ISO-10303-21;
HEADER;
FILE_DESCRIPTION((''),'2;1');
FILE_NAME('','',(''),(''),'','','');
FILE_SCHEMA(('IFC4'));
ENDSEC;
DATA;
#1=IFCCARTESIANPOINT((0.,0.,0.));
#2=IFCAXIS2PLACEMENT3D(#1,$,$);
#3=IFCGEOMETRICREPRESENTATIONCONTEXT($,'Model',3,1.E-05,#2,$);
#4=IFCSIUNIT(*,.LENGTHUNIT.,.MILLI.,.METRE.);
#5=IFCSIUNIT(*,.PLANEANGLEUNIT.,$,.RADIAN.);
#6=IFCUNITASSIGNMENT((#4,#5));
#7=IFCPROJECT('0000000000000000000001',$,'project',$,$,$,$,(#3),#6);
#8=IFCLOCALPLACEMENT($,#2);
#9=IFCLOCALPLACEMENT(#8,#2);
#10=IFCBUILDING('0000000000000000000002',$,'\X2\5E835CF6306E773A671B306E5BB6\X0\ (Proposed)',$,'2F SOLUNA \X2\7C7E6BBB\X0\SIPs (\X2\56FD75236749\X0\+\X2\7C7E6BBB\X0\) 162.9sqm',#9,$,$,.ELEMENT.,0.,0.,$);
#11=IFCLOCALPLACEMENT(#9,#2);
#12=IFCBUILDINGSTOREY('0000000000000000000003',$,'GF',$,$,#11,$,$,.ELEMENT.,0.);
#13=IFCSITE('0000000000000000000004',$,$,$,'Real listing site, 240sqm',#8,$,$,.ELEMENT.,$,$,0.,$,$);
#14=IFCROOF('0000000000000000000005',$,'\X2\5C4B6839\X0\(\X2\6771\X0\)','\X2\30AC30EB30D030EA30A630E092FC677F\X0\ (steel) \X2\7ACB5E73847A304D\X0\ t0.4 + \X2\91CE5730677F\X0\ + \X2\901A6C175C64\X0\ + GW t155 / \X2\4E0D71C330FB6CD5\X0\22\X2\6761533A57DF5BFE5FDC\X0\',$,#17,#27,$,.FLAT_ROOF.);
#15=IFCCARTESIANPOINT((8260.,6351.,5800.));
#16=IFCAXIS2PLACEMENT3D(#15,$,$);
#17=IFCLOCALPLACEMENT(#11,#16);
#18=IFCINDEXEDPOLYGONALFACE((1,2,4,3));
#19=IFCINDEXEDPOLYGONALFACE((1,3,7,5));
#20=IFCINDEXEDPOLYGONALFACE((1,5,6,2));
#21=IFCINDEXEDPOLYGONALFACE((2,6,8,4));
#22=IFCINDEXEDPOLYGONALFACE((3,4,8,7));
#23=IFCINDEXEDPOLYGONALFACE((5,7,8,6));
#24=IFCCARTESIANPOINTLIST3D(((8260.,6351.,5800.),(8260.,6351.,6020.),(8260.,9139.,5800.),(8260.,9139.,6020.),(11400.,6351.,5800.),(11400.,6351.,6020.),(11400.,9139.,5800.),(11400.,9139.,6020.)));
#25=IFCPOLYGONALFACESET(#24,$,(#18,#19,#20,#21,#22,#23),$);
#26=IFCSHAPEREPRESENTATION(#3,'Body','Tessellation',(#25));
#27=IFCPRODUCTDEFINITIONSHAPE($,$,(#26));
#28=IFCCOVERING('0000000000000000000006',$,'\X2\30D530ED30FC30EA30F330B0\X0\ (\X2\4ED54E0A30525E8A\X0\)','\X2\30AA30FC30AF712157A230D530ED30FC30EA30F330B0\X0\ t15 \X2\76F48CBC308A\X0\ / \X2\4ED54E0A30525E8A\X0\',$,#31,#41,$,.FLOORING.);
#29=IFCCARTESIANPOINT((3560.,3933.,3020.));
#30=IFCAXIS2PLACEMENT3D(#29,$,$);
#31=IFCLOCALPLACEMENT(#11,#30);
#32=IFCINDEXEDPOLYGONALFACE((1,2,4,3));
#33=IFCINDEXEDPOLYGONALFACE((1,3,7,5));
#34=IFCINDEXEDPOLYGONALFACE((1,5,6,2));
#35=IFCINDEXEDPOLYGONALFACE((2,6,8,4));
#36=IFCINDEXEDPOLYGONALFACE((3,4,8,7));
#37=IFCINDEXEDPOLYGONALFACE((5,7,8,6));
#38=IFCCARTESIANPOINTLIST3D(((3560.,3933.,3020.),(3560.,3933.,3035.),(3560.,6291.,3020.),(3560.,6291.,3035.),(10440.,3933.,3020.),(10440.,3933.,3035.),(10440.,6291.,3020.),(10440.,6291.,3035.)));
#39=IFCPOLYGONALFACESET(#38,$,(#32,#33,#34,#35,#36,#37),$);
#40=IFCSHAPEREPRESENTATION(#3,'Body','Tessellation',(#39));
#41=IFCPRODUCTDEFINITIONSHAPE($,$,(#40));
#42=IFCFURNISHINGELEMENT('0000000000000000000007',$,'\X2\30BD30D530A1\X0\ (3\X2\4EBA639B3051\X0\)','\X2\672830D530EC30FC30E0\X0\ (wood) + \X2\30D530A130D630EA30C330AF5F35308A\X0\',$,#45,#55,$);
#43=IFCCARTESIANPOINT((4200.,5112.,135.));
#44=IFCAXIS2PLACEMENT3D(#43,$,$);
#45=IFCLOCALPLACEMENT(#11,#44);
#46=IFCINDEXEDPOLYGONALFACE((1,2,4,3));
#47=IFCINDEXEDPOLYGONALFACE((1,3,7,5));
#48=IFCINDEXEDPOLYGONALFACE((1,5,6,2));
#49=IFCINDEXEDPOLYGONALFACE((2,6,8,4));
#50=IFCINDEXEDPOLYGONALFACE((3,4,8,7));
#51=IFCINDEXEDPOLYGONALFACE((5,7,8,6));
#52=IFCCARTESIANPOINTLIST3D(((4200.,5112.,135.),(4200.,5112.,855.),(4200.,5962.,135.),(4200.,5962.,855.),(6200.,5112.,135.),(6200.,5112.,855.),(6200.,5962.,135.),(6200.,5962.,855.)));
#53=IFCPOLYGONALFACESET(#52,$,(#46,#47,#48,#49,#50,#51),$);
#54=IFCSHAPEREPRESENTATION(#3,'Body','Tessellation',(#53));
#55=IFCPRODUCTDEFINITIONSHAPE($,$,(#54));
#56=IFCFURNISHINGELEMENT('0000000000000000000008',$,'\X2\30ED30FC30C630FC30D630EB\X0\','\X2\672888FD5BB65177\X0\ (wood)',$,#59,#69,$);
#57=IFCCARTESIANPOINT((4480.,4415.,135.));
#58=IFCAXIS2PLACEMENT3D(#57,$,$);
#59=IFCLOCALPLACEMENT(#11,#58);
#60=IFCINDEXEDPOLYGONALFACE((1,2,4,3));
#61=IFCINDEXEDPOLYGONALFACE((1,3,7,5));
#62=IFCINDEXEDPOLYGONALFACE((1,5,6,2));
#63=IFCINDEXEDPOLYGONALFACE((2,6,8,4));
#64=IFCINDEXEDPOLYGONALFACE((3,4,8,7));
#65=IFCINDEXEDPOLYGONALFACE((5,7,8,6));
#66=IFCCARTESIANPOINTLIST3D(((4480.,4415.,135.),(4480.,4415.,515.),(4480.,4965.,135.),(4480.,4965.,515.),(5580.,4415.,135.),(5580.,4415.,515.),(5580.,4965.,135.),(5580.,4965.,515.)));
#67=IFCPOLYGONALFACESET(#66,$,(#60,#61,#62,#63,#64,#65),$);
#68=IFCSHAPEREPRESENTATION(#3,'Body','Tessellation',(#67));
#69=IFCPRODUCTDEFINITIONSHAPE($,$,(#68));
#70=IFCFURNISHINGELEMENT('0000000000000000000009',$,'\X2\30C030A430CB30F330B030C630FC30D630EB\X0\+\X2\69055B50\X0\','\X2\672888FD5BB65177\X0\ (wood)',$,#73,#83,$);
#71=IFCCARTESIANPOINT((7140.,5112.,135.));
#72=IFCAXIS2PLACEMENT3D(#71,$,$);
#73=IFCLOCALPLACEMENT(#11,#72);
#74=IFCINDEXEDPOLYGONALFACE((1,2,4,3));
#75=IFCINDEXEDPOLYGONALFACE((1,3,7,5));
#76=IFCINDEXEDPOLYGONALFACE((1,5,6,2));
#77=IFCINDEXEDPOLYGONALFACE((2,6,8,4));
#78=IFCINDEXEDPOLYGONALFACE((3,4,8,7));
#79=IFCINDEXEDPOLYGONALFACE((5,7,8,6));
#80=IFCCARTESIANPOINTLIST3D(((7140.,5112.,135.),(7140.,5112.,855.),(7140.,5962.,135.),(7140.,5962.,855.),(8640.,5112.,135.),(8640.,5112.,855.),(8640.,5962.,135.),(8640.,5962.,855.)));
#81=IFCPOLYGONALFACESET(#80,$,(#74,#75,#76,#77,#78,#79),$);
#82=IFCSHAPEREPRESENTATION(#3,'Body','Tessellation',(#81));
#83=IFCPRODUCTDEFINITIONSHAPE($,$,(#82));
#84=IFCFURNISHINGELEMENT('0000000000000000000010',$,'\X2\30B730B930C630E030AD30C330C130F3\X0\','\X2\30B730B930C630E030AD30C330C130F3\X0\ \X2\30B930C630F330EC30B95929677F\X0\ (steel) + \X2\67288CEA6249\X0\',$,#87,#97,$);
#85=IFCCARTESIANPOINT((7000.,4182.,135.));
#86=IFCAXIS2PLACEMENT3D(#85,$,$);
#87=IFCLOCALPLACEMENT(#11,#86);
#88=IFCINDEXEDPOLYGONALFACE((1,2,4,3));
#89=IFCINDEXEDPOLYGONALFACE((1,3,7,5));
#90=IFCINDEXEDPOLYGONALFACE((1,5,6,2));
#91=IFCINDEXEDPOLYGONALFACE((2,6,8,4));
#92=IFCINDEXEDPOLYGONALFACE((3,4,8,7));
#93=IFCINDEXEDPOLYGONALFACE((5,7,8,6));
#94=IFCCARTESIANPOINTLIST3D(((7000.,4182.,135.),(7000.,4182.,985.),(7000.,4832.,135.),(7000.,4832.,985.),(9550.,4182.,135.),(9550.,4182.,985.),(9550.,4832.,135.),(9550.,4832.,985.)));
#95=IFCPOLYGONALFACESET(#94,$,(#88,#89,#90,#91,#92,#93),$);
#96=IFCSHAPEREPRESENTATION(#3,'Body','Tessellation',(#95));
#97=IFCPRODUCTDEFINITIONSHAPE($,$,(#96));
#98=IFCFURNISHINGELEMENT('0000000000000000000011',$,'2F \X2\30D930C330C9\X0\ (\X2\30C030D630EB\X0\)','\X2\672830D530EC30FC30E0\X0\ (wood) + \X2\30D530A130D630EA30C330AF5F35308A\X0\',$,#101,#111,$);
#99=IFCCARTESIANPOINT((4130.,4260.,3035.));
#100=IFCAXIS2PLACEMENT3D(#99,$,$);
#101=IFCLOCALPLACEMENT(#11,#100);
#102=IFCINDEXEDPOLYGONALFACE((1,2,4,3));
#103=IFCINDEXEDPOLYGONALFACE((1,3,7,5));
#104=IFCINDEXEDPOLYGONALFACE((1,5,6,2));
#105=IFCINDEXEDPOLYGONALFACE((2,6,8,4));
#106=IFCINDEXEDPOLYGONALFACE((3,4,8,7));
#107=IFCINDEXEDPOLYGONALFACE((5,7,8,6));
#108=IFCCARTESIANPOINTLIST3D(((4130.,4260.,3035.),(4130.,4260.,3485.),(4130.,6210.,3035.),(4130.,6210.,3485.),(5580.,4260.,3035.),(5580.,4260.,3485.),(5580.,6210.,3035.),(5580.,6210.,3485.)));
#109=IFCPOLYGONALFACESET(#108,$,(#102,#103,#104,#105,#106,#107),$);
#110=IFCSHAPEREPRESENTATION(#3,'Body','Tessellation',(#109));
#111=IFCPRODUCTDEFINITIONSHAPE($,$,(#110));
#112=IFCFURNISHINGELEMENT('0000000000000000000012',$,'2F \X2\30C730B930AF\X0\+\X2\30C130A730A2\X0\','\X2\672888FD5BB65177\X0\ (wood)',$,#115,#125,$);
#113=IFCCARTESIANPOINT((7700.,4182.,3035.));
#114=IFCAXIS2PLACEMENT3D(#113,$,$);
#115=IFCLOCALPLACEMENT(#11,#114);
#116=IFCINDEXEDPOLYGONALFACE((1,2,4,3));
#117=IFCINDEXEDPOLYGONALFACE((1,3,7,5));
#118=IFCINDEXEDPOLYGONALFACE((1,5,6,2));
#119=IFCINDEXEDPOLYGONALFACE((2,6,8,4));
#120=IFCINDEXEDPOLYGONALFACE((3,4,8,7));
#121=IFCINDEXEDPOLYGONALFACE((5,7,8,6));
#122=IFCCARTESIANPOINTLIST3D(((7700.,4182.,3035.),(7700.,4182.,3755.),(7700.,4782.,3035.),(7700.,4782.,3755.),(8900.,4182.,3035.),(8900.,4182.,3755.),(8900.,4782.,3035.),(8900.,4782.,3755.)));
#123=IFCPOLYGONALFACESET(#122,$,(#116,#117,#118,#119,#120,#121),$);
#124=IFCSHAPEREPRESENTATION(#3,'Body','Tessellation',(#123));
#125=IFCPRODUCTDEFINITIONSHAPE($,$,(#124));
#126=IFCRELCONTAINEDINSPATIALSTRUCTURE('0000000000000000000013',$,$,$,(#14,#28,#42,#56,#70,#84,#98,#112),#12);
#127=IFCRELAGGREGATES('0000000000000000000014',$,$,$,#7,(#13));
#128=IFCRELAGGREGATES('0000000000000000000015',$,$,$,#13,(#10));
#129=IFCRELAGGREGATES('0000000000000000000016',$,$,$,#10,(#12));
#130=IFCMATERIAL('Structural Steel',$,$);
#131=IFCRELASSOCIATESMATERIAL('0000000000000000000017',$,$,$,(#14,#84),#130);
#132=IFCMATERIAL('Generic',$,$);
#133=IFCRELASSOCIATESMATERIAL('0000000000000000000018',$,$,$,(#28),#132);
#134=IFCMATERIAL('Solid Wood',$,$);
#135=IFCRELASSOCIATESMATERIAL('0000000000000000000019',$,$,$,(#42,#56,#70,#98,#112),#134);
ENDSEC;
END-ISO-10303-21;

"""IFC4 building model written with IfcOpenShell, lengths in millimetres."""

from ifc_helpers import new_model, si_unit, frame, frame_2d, origin, place, context, project, spatial, rectangle, extrude, material, element, save


model = new_model("IFC4")

# Units and contexts
model_context = context("Model", 3, precision=1e-05, world=origin())
ifc_project = project(units=[si_unit("LENGTHUNIT", "METRE", prefix="MILLI"), si_unit("PLANEANGLEUNIT", "RADIAN")], contexts=[model_context])

# Site, building, storey
site_placement = place(None, origin())
site = spatial("IfcSite", under=ifc_project, at=site_placement, ObjectType="Real listing site, 240sqm", CompositionType="ELEMENT", RefElevation=0.0)
building_placement = place(site_placement, origin())
building = spatial("IfcBuilding", under=site, at=building_placement, Name="広島の眺望の家 (Proposed)", ObjectType="2F SOLUNA 籾殻SIPs (国産杉+籾殻) 162.9sqm", CompositionType="ELEMENT", ElevationOfRefHeight=0.0, ElevationOfTerrain=0.0)
storey_placement = place(building_placement, origin())
storey = spatial("IfcBuildingStorey", under=building, at=storey_placement, Name="GF", CompositionType="ELEMENT", Elevation=0.0)

# Shared definitions
ifc_material_1 = material(Name="Solid Wood")

# Shared definitions
ifc_material_2 = material(Name="Generic")

# Roof
ifc_material_3 = material(Name="Structural Steel")
roof_placement = place(storey_placement, frame((8260.0, 6351.0, 5800.0)))
element("IfcRoof", 1, at=roof_placement, inside=storey, material=ifc_material_3, Name="屋根(東)", Description="ガルバリウム鋼板 (steel) 立平葺き t0.4 + 野地板 + 通気層 + GW t155 / 不燃・法22条区域対応", PredefinedType="FLAT_ROOF", context=model_context, shape_type="SweptSolid", body=[
    extrude(rectangle(XDim=3140.0, YDim=2788.0, at=frame_2d((1570.0, 1394.0))), frame((8260.0, 6351.0, 5800.0)), (0.0, 0.0, 1.0), 220.0),
])

# Covering
covering_placement = place(storey_placement, frame((3560.0, 3933.0, 3020.0)))
element("IfcCovering", 2, at=covering_placement, inside=storey, material=ifc_material_2, Name="フローリング (仕上げ床)", Description="オーク無垢フローリング t15 直貼り / 仕上げ床", PredefinedType="FLOORING", context=model_context, shape_type="SweptSolid", body=[
    extrude(rectangle(XDim=6880.0, YDim=2358.0, at=frame_2d((3440.0, 1179.0))), frame((3560.0, 3933.0, 3020.0)), (0.0, 0.0, 1.0), 15.0),
])

# Furnishing elements
furnishing_1_placement = place(storey_placement, frame((4200.0, 5112.0, 135.0)))
element("IfcFurnishingElement", 3, at=furnishing_1_placement, inside=storey, material=ifc_material_1, Name="ソファ (3人掛け)", Description="木フレーム (wood) + ファブリック張り", context=model_context, shape_type="SweptSolid", body=[
    extrude(rectangle(XDim=2000.0, YDim=850.0, at=frame_2d((1000.0, 425.0))), frame((4200.0, 5112.0, 135.0)), (0.0, 0.0, 1.0), 720.0),
])
furnishing_2_placement = place(storey_placement, frame((4480.0, 4415.0, 135.0)))
element("IfcFurnishingElement", 4, at=furnishing_2_placement, inside=storey, material=ifc_material_1, Name="ローテーブル", Description="木製家具 (wood)", context=model_context, shape_type="SweptSolid", body=[
    extrude(rectangle(XDim=1100.0, YDim=550.0, at=frame_2d((550.0, 275.0))), frame((4480.0, 4415.0, 135.0)), (0.0, 0.0, 1.0), 380.0),
])
furnishing_3_placement = place(storey_placement, frame((7140.0, 5112.0, 135.0)))
element("IfcFurnishingElement", 5, at=furnishing_3_placement, inside=storey, material=ifc_material_1, Name="ダイニングテーブル+椅子", Description="木製家具 (wood)", context=model_context, shape_type="SweptSolid", body=[
    extrude(rectangle(XDim=1500.0, YDim=850.0, at=frame_2d((750.0, 425.0))), frame((7140.0, 5112.0, 135.0)), (0.0, 0.0, 1.0), 720.0),
])
furnishing_4_placement = place(storey_placement, frame((7000.0, 4182.0, 135.0)))
element("IfcFurnishingElement", 6, at=furnishing_4_placement, inside=storey, material=ifc_material_3, Name="システムキッチン", Description="システムキッチン ステンレス天板 (steel) + 木質扉", context=model_context, shape_type="SweptSolid", body=[
    extrude(rectangle(XDim=2550.0, YDim=650.0, at=frame_2d((1275.0, 325.0))), frame((7000.0, 4182.0, 135.0)), (0.0, 0.0, 1.0), 850.0),
])
furnishing_5_placement = place(storey_placement, frame((4130.0, 4260.0, 3035.0)))
element("IfcFurnishingElement", 7, at=furnishing_5_placement, inside=storey, material=ifc_material_1, Name="2F ベッド (ダブル)", Description="木フレーム (wood) + ファブリック張り", context=model_context, shape_type="SweptSolid", body=[
    extrude(rectangle(XDim=1450.0, YDim=1950.0, at=frame_2d((725.0, 975.0))), frame((4130.0, 4260.0, 3035.0)), (0.0, 0.0, 1.0), 450.0),
])
furnishing_6_placement = place(storey_placement, frame((7700.0, 4182.0, 3035.0)))
element("IfcFurnishingElement", 8, at=furnishing_6_placement, inside=storey, material=ifc_material_1, Name="2F デスク+チェア", Description="木製家具 (wood)", context=model_context, shape_type="SweptSolid", body=[
    extrude(rectangle(XDim=1200.0, YDim=600.0, at=frame_2d((600.0, 300.0))), frame((7700.0, 4182.0, 3035.0)), (0.0, 0.0, 1.0), 720.0),
])

save(model, "model.ifc")
